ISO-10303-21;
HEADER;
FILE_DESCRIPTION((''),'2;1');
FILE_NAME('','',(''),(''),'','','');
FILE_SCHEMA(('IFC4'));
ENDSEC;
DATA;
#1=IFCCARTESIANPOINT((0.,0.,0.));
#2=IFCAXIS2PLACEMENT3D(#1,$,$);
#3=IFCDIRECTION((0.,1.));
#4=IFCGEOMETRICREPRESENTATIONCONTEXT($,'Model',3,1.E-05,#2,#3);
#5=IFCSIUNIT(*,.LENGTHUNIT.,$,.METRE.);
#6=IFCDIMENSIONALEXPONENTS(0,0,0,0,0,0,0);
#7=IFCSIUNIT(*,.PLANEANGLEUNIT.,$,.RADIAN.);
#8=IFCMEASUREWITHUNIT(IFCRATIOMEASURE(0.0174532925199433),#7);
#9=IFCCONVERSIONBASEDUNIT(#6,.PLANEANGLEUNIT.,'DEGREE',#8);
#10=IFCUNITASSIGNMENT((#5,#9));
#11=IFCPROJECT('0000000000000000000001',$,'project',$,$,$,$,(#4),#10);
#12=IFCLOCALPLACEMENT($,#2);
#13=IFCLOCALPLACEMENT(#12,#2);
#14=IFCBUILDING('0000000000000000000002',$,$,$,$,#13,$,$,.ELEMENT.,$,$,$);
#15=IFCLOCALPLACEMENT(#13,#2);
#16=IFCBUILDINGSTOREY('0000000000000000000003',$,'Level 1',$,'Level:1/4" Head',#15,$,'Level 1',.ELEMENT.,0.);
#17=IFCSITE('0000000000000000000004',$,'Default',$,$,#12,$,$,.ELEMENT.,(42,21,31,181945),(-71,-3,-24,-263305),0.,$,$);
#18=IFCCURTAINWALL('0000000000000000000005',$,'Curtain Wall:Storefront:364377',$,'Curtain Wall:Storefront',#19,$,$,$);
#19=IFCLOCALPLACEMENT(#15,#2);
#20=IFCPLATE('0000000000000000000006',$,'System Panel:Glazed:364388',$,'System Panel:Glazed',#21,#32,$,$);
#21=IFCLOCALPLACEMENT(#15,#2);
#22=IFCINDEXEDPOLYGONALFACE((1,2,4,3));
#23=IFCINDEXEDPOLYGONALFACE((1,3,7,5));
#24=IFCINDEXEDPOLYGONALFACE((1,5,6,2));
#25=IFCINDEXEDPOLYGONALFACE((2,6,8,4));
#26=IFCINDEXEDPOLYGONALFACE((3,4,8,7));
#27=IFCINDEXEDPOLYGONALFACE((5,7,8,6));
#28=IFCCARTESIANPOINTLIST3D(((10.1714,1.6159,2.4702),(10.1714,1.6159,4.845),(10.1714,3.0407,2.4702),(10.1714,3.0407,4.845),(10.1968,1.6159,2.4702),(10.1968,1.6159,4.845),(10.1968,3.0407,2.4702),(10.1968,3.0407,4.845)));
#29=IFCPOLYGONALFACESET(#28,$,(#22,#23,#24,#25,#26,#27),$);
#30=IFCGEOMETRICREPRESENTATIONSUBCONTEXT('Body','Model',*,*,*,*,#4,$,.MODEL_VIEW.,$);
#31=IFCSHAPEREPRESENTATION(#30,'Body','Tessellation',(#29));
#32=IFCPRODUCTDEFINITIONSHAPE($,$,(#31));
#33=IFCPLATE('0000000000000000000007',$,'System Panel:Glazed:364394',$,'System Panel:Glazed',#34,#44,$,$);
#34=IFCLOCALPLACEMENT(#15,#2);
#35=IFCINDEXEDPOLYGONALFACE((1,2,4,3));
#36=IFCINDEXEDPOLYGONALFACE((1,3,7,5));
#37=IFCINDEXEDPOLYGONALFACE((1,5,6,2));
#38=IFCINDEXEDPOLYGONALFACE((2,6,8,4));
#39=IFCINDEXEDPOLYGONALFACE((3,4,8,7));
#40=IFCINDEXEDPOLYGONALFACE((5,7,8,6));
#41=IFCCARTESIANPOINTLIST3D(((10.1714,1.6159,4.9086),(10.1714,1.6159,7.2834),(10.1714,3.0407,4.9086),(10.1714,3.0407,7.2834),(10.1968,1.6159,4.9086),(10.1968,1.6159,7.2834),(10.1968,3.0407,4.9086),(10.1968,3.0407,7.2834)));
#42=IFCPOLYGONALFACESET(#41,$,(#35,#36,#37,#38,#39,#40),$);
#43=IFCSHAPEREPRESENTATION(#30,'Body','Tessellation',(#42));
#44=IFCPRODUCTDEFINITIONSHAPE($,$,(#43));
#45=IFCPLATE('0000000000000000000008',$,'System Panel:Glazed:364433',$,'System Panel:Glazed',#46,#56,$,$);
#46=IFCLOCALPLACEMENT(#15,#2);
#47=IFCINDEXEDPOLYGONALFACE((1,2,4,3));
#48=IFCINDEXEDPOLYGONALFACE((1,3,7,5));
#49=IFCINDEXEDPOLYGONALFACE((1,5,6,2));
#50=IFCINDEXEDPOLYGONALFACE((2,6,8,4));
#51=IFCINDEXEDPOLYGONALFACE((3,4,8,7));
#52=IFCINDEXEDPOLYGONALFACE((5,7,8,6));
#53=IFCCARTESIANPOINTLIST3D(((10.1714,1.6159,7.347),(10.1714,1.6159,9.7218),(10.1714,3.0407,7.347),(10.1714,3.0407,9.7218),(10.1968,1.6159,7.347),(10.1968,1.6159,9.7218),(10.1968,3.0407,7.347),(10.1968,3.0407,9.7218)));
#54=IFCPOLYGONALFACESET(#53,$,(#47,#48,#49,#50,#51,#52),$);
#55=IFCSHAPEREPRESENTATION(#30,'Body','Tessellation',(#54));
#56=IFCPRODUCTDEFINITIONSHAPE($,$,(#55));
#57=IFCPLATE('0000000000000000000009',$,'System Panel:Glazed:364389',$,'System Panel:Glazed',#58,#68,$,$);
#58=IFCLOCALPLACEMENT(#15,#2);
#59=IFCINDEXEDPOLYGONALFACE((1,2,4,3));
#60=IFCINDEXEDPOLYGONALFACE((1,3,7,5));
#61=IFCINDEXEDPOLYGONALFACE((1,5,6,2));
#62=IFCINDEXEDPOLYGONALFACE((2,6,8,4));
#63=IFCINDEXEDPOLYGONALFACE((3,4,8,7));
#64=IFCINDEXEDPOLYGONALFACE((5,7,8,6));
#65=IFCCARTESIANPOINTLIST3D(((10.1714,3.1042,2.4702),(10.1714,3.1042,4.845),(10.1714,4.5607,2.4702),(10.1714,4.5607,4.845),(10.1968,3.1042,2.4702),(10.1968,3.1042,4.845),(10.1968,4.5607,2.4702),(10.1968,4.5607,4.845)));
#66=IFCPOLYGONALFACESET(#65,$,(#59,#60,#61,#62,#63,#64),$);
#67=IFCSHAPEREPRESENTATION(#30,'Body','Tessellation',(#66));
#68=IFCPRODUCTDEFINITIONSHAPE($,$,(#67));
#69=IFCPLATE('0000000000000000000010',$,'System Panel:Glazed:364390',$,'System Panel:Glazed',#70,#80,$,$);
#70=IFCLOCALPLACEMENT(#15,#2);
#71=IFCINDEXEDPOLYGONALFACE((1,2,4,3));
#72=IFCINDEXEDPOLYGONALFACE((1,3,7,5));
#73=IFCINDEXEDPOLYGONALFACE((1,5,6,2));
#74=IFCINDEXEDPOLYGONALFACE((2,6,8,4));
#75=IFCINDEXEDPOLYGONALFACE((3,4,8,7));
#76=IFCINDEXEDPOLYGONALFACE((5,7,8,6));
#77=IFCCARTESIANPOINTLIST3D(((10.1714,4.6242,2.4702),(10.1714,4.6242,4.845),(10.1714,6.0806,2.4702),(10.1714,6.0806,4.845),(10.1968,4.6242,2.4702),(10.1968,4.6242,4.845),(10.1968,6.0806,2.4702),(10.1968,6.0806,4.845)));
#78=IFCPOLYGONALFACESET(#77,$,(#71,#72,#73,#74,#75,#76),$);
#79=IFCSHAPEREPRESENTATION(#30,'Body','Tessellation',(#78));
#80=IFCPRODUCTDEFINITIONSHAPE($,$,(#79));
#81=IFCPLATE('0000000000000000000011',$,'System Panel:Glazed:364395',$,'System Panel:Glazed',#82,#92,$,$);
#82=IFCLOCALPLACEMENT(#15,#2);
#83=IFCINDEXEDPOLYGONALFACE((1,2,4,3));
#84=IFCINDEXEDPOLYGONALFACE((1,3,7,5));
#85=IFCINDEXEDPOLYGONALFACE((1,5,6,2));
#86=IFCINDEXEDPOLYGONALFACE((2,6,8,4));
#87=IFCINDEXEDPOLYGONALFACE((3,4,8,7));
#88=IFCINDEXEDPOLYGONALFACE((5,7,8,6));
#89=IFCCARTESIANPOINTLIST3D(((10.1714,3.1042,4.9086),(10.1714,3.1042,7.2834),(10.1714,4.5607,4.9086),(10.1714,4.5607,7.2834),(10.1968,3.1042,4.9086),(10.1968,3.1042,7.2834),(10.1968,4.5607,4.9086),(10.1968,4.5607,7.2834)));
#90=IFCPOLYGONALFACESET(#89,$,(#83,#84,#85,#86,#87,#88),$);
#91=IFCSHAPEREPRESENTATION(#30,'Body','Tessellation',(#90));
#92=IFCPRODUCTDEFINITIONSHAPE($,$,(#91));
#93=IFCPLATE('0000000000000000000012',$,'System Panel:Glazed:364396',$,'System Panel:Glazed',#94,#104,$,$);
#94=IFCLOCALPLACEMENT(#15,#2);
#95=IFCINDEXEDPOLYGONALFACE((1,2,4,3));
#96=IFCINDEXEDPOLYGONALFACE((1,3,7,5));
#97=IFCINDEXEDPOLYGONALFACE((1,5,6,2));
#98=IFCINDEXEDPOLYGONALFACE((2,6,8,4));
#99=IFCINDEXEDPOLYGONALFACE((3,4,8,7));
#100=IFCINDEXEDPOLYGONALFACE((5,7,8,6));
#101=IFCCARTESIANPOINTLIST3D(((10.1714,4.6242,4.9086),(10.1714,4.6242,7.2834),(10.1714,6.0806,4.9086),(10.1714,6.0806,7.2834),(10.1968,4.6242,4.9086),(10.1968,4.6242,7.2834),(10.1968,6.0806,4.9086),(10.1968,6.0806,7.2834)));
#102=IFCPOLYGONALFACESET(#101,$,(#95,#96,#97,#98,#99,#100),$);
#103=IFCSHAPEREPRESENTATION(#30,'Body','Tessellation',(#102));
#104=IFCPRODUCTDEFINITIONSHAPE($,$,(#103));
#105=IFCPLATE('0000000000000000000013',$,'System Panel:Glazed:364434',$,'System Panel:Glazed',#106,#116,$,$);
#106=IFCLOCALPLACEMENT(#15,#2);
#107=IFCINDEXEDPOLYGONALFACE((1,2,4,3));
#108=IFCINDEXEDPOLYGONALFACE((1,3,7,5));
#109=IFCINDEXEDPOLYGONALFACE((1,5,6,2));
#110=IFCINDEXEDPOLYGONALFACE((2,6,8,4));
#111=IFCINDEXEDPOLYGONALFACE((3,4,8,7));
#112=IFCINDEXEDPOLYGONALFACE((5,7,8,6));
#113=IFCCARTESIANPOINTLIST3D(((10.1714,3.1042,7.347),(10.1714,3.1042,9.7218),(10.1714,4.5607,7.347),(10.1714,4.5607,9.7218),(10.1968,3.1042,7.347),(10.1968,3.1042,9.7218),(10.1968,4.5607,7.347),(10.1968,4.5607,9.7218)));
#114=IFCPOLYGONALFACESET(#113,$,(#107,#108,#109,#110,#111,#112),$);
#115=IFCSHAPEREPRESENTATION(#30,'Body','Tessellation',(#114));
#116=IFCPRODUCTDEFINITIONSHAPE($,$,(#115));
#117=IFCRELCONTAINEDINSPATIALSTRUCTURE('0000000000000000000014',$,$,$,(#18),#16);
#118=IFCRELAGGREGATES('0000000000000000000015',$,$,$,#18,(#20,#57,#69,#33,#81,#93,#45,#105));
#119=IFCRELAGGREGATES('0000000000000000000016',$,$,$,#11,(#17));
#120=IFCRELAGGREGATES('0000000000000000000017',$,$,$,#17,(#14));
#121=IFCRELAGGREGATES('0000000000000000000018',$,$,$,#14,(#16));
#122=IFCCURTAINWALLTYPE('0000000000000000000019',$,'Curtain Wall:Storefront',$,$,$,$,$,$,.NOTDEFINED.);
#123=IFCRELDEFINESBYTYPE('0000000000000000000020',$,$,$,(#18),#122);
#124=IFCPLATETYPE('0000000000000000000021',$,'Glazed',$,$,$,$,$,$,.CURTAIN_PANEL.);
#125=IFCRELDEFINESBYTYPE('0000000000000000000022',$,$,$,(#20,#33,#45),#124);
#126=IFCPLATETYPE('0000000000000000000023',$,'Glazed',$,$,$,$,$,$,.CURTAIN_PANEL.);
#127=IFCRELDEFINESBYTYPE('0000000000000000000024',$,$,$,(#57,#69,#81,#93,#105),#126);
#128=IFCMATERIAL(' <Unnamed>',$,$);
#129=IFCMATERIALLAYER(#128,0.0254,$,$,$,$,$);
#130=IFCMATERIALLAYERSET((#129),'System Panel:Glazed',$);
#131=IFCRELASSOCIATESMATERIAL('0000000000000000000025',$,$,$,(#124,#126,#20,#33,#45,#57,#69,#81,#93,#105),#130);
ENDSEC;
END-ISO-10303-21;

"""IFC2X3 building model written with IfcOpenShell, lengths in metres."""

from ifc_helpers import new_model, entity, si_unit, converted_unit, direction, frame, frame_2d, origin, origin_2d_with_axis, place, context, subcontext, project, spatial, rectangle, extrude, source, transform, mapped, material, layer, layer_set, layer_usage, type_object, type_shapes, element, aggregate, save


model = new_model("IFC2X3")

# Units and contexts
model_context = context("Model", 3, precision=1e-05, world=origin(), true_north=direction((0.0, 1.0)))
body_context = subcontext(model_context, "Body", "Model", "MODEL_VIEW")
ifc_project = project(units=[si_unit("LENGTHUNIT", "METRE"), converted_unit("PLANEANGLEUNIT", "DEGREE", entity("IfcRatioMeasure", 0.0174532925199433), si_unit("PLANEANGLEUNIT", "RADIAN"), dimensions=[0, 0, 0, 0, 0, 0, 0])], contexts=[model_context])

# Site, building, storey
site_placement = place(None, origin())
site = spatial("IfcSite", under=ifc_project, at=site_placement, Name="Default", CompositionType="ELEMENT", RefLatitude=(42, 21, 31, 181945), RefLongitude=(-71, -3, -24, -263305), RefElevation=0.0)
building_placement = place(site_placement, origin())
building = spatial("IfcBuilding", under=site, at=building_placement, CompositionType="ELEMENT")
storey_placement = place(building_placement, origin())
storey = spatial("IfcBuildingStorey", under=building, at=storey_placement, Name="Level 1", ObjectType="Level:1/4\" Head", LongName="Level 1", CompositionType="ELEMENT", Elevation=0.0)

# Shared definitions
curtain_wall_type = type_object("IfcCurtainWallType", Name="Curtain Wall:Storefront", PredefinedType="NOTDEFINED")

# Curtain wall, plates
curtain_wall_1_placement = place(storey_placement, origin())
curtain_wall_1 = element("IfcCurtainWall", 1, at=curtain_wall_1_placement, inside=storey, type_object=curtain_wall_type, Name="Curtain Wall:Storefront:364377", ObjectType="Curtain Wall:Storefront")
ifc_material_1 = material(Name=" <Unnamed>")
ifc_layer_1 = layer(ifc_material_1, 0.0254)
ifc_layer_set_1 = layer_set([ifc_layer_1], Name="System Panel:Glazed")
ifc_layer_usage_1 = layer_usage(ifc_layer_set_1, "AXIS3", "POSITIVE", 0.1042)
plate_type_1 = type_object("IfcPlateType", Name="Glazed", PredefinedType="CURTAIN_PANEL", material=ifc_layer_set_1)
shared_shape_1 = source(origin(), body_context, "Body", "SweptSolid", [
    extrude(rectangle(XDim=0.0254, YDim=1.4248, at=frame_2d((0.0, 0.0), x_axis=(1.0, 0.0))), frame((0.7124, 0.0127, 0.0), z_axis=(0.0, 0.0, 1.0), x_axis=(0.0, 1.0, 0.0)), (0.0, 0.0, 1.0), 2.3749),
])
type_shapes(plate_type_1, [shared_shape_1])
plate_1_placement = place(curtain_wall_1_placement, frame((10.1968, 1.6159, 2.4701), z_axis=(0.0, 0.0, 1.0), x_axis=(0.0, 1.0, 0.0)))
plate_1 = element("IfcPlate", 2, at=plate_1_placement, type_object=plate_type_1, material=ifc_layer_usage_1, Name="System Panel:Glazed:364388", ObjectType="System Panel:Glazed", context=body_context, shape_type="MappedRepresentation", body=[
    mapped(shared_shape_1, transform((0.0, 0.0, 0.0), scale=1.0)),
])
ifc_layer_usage_2 = layer_usage(ifc_layer_set_1, "AXIS3", "POSITIVE", 0.1042)
plate_2_placement = place(curtain_wall_1_placement, frame((10.1968, 1.6159, 4.9085), z_axis=(0.0, 0.0, 1.0), x_axis=(0.0, 1.0, 0.0)))
plate_2 = element("IfcPlate", 3, at=plate_2_placement, type_object=plate_type_1, material=ifc_layer_usage_2, Name="System Panel:Glazed:364394", ObjectType="System Panel:Glazed", context=body_context, shape_type="MappedRepresentation", body=[
    mapped(shared_shape_1, transform((0.0, 0.0, 0.0), scale=1.0)),
])
ifc_layer_usage_3 = layer_usage(ifc_layer_set_1, "AXIS3", "POSITIVE", 0.1042)
plate_3_placement = place(curtain_wall_1_placement, frame((10.1968, 1.6159, 7.3469), z_axis=(0.0, 0.0, 1.0), x_axis=(0.0, 1.0, 0.0)))
plate_3 = element("IfcPlate", 4, at=plate_3_placement, type_object=plate_type_1, material=ifc_layer_usage_3, Name="System Panel:Glazed:364433", ObjectType="System Panel:Glazed", context=body_context, shape_type="MappedRepresentation", body=[
    mapped(shared_shape_1, transform((0.0, 0.0, 0.0), scale=1.0)),
])
ifc_layer_usage_4 = layer_usage(ifc_layer_set_1, "AXIS3", "POSITIVE", 0.1042)
plate_type_2 = type_object("IfcPlateType", Name="Glazed", PredefinedType="CURTAIN_PANEL", material=ifc_layer_set_1)
shared_shape_2 = source(origin(), body_context, "Body", "SweptSolid", [
    extrude(rectangle(XDim=0.0254, YDim=1.4565, at=origin_2d_with_axis()), frame((0.7282, 0.0127, 0.0), z_axis=(0.0, 0.0, 1.0), x_axis=(0.0, 1.0, 0.0)), (0.0, 0.0, 1.0), 2.3749),
])
type_shapes(plate_type_2, [shared_shape_2])
plate_4_placement = place(curtain_wall_1_placement, frame((10.1968, 3.1042, 2.4701), z_axis=(0.0, 0.0, 1.0), x_axis=(0.0, 1.0, 0.0)))
plate_4 = element("IfcPlate", 5, at=plate_4_placement, type_object=plate_type_2, material=ifc_layer_usage_4, Name="System Panel:Glazed:364389", ObjectType="System Panel:Glazed", context=body_context, shape_type="MappedRepresentation", body=[
    mapped(shared_shape_2, transform((0.0, 0.0, 0.0), scale=1.0)),
])
ifc_layer_usage_5 = layer_usage(ifc_layer_set_1, "AXIS3", "POSITIVE", 0.1042)
plate_5_placement = place(curtain_wall_1_placement, frame((10.1968, 4.6242, 2.4701), z_axis=(0.0, 0.0, 1.0), x_axis=(0.0, 1.0, 0.0)))
plate_5 = element("IfcPlate", 6, at=plate_5_placement, type_object=plate_type_2, material=ifc_layer_usage_5, Name="System Panel:Glazed:364390", ObjectType="System Panel:Glazed", context=body_context, shape_type="MappedRepresentation", body=[
    mapped(shared_shape_2, transform((0.0, 0.0, 0.0), scale=1.0)),
])
ifc_layer_usage_6 = layer_usage(ifc_layer_set_1, "AXIS3", "POSITIVE", 0.1042)
plate_6_placement = place(curtain_wall_1_placement, frame((10.1968, 3.1042, 4.9085), z_axis=(0.0, 0.0, 1.0), x_axis=(0.0, 1.0, 0.0)))
plate_6 = element("IfcPlate", 7, at=plate_6_placement, type_object=plate_type_2, material=ifc_layer_usage_6, Name="System Panel:Glazed:364395", ObjectType="System Panel:Glazed", context=body_context, shape_type="MappedRepresentation", body=[
    mapped(shared_shape_2, transform((0.0, 0.0, 0.0), scale=1.0)),
])
ifc_layer_usage_7 = layer_usage(ifc_layer_set_1, "AXIS3", "POSITIVE", 0.1042)
plate_7_placement = place(curtain_wall_1_placement, frame((10.1968, 4.6242, 4.9085), z_axis=(0.0, 0.0, 1.0), x_axis=(0.0, 1.0, 0.0)))
plate_7 = element("IfcPlate", 8, at=plate_7_placement, type_object=plate_type_2, material=ifc_layer_usage_7, Name="System Panel:Glazed:364396", ObjectType="System Panel:Glazed", context=body_context, shape_type="MappedRepresentation", body=[
    mapped(shared_shape_2, transform((0.0, 0.0, 0.0), scale=1.0)),
])
ifc_layer_usage_8 = layer_usage(ifc_layer_set_1, "AXIS3", "POSITIVE", 0.1042)
plate_8_placement = place(curtain_wall_1_placement, frame((10.1968, 3.1042, 7.3469), z_axis=(0.0, 0.0, 1.0), x_axis=(0.0, 1.0, 0.0)))
plate_8 = element("IfcPlate", 9, at=plate_8_placement, type_object=plate_type_2, material=ifc_layer_usage_8, Name="System Panel:Glazed:364434", ObjectType="System Panel:Glazed", context=body_context, shape_type="MappedRepresentation", body=[
    mapped(shared_shape_2, transform((0.0, 0.0, 0.0), scale=1.0)),
])
aggregate(curtain_wall_1, [plate_1, plate_4, plate_5, plate_2, plate_6, plate_7, plate_3, plate_8])

save(model, "model.ifc")
